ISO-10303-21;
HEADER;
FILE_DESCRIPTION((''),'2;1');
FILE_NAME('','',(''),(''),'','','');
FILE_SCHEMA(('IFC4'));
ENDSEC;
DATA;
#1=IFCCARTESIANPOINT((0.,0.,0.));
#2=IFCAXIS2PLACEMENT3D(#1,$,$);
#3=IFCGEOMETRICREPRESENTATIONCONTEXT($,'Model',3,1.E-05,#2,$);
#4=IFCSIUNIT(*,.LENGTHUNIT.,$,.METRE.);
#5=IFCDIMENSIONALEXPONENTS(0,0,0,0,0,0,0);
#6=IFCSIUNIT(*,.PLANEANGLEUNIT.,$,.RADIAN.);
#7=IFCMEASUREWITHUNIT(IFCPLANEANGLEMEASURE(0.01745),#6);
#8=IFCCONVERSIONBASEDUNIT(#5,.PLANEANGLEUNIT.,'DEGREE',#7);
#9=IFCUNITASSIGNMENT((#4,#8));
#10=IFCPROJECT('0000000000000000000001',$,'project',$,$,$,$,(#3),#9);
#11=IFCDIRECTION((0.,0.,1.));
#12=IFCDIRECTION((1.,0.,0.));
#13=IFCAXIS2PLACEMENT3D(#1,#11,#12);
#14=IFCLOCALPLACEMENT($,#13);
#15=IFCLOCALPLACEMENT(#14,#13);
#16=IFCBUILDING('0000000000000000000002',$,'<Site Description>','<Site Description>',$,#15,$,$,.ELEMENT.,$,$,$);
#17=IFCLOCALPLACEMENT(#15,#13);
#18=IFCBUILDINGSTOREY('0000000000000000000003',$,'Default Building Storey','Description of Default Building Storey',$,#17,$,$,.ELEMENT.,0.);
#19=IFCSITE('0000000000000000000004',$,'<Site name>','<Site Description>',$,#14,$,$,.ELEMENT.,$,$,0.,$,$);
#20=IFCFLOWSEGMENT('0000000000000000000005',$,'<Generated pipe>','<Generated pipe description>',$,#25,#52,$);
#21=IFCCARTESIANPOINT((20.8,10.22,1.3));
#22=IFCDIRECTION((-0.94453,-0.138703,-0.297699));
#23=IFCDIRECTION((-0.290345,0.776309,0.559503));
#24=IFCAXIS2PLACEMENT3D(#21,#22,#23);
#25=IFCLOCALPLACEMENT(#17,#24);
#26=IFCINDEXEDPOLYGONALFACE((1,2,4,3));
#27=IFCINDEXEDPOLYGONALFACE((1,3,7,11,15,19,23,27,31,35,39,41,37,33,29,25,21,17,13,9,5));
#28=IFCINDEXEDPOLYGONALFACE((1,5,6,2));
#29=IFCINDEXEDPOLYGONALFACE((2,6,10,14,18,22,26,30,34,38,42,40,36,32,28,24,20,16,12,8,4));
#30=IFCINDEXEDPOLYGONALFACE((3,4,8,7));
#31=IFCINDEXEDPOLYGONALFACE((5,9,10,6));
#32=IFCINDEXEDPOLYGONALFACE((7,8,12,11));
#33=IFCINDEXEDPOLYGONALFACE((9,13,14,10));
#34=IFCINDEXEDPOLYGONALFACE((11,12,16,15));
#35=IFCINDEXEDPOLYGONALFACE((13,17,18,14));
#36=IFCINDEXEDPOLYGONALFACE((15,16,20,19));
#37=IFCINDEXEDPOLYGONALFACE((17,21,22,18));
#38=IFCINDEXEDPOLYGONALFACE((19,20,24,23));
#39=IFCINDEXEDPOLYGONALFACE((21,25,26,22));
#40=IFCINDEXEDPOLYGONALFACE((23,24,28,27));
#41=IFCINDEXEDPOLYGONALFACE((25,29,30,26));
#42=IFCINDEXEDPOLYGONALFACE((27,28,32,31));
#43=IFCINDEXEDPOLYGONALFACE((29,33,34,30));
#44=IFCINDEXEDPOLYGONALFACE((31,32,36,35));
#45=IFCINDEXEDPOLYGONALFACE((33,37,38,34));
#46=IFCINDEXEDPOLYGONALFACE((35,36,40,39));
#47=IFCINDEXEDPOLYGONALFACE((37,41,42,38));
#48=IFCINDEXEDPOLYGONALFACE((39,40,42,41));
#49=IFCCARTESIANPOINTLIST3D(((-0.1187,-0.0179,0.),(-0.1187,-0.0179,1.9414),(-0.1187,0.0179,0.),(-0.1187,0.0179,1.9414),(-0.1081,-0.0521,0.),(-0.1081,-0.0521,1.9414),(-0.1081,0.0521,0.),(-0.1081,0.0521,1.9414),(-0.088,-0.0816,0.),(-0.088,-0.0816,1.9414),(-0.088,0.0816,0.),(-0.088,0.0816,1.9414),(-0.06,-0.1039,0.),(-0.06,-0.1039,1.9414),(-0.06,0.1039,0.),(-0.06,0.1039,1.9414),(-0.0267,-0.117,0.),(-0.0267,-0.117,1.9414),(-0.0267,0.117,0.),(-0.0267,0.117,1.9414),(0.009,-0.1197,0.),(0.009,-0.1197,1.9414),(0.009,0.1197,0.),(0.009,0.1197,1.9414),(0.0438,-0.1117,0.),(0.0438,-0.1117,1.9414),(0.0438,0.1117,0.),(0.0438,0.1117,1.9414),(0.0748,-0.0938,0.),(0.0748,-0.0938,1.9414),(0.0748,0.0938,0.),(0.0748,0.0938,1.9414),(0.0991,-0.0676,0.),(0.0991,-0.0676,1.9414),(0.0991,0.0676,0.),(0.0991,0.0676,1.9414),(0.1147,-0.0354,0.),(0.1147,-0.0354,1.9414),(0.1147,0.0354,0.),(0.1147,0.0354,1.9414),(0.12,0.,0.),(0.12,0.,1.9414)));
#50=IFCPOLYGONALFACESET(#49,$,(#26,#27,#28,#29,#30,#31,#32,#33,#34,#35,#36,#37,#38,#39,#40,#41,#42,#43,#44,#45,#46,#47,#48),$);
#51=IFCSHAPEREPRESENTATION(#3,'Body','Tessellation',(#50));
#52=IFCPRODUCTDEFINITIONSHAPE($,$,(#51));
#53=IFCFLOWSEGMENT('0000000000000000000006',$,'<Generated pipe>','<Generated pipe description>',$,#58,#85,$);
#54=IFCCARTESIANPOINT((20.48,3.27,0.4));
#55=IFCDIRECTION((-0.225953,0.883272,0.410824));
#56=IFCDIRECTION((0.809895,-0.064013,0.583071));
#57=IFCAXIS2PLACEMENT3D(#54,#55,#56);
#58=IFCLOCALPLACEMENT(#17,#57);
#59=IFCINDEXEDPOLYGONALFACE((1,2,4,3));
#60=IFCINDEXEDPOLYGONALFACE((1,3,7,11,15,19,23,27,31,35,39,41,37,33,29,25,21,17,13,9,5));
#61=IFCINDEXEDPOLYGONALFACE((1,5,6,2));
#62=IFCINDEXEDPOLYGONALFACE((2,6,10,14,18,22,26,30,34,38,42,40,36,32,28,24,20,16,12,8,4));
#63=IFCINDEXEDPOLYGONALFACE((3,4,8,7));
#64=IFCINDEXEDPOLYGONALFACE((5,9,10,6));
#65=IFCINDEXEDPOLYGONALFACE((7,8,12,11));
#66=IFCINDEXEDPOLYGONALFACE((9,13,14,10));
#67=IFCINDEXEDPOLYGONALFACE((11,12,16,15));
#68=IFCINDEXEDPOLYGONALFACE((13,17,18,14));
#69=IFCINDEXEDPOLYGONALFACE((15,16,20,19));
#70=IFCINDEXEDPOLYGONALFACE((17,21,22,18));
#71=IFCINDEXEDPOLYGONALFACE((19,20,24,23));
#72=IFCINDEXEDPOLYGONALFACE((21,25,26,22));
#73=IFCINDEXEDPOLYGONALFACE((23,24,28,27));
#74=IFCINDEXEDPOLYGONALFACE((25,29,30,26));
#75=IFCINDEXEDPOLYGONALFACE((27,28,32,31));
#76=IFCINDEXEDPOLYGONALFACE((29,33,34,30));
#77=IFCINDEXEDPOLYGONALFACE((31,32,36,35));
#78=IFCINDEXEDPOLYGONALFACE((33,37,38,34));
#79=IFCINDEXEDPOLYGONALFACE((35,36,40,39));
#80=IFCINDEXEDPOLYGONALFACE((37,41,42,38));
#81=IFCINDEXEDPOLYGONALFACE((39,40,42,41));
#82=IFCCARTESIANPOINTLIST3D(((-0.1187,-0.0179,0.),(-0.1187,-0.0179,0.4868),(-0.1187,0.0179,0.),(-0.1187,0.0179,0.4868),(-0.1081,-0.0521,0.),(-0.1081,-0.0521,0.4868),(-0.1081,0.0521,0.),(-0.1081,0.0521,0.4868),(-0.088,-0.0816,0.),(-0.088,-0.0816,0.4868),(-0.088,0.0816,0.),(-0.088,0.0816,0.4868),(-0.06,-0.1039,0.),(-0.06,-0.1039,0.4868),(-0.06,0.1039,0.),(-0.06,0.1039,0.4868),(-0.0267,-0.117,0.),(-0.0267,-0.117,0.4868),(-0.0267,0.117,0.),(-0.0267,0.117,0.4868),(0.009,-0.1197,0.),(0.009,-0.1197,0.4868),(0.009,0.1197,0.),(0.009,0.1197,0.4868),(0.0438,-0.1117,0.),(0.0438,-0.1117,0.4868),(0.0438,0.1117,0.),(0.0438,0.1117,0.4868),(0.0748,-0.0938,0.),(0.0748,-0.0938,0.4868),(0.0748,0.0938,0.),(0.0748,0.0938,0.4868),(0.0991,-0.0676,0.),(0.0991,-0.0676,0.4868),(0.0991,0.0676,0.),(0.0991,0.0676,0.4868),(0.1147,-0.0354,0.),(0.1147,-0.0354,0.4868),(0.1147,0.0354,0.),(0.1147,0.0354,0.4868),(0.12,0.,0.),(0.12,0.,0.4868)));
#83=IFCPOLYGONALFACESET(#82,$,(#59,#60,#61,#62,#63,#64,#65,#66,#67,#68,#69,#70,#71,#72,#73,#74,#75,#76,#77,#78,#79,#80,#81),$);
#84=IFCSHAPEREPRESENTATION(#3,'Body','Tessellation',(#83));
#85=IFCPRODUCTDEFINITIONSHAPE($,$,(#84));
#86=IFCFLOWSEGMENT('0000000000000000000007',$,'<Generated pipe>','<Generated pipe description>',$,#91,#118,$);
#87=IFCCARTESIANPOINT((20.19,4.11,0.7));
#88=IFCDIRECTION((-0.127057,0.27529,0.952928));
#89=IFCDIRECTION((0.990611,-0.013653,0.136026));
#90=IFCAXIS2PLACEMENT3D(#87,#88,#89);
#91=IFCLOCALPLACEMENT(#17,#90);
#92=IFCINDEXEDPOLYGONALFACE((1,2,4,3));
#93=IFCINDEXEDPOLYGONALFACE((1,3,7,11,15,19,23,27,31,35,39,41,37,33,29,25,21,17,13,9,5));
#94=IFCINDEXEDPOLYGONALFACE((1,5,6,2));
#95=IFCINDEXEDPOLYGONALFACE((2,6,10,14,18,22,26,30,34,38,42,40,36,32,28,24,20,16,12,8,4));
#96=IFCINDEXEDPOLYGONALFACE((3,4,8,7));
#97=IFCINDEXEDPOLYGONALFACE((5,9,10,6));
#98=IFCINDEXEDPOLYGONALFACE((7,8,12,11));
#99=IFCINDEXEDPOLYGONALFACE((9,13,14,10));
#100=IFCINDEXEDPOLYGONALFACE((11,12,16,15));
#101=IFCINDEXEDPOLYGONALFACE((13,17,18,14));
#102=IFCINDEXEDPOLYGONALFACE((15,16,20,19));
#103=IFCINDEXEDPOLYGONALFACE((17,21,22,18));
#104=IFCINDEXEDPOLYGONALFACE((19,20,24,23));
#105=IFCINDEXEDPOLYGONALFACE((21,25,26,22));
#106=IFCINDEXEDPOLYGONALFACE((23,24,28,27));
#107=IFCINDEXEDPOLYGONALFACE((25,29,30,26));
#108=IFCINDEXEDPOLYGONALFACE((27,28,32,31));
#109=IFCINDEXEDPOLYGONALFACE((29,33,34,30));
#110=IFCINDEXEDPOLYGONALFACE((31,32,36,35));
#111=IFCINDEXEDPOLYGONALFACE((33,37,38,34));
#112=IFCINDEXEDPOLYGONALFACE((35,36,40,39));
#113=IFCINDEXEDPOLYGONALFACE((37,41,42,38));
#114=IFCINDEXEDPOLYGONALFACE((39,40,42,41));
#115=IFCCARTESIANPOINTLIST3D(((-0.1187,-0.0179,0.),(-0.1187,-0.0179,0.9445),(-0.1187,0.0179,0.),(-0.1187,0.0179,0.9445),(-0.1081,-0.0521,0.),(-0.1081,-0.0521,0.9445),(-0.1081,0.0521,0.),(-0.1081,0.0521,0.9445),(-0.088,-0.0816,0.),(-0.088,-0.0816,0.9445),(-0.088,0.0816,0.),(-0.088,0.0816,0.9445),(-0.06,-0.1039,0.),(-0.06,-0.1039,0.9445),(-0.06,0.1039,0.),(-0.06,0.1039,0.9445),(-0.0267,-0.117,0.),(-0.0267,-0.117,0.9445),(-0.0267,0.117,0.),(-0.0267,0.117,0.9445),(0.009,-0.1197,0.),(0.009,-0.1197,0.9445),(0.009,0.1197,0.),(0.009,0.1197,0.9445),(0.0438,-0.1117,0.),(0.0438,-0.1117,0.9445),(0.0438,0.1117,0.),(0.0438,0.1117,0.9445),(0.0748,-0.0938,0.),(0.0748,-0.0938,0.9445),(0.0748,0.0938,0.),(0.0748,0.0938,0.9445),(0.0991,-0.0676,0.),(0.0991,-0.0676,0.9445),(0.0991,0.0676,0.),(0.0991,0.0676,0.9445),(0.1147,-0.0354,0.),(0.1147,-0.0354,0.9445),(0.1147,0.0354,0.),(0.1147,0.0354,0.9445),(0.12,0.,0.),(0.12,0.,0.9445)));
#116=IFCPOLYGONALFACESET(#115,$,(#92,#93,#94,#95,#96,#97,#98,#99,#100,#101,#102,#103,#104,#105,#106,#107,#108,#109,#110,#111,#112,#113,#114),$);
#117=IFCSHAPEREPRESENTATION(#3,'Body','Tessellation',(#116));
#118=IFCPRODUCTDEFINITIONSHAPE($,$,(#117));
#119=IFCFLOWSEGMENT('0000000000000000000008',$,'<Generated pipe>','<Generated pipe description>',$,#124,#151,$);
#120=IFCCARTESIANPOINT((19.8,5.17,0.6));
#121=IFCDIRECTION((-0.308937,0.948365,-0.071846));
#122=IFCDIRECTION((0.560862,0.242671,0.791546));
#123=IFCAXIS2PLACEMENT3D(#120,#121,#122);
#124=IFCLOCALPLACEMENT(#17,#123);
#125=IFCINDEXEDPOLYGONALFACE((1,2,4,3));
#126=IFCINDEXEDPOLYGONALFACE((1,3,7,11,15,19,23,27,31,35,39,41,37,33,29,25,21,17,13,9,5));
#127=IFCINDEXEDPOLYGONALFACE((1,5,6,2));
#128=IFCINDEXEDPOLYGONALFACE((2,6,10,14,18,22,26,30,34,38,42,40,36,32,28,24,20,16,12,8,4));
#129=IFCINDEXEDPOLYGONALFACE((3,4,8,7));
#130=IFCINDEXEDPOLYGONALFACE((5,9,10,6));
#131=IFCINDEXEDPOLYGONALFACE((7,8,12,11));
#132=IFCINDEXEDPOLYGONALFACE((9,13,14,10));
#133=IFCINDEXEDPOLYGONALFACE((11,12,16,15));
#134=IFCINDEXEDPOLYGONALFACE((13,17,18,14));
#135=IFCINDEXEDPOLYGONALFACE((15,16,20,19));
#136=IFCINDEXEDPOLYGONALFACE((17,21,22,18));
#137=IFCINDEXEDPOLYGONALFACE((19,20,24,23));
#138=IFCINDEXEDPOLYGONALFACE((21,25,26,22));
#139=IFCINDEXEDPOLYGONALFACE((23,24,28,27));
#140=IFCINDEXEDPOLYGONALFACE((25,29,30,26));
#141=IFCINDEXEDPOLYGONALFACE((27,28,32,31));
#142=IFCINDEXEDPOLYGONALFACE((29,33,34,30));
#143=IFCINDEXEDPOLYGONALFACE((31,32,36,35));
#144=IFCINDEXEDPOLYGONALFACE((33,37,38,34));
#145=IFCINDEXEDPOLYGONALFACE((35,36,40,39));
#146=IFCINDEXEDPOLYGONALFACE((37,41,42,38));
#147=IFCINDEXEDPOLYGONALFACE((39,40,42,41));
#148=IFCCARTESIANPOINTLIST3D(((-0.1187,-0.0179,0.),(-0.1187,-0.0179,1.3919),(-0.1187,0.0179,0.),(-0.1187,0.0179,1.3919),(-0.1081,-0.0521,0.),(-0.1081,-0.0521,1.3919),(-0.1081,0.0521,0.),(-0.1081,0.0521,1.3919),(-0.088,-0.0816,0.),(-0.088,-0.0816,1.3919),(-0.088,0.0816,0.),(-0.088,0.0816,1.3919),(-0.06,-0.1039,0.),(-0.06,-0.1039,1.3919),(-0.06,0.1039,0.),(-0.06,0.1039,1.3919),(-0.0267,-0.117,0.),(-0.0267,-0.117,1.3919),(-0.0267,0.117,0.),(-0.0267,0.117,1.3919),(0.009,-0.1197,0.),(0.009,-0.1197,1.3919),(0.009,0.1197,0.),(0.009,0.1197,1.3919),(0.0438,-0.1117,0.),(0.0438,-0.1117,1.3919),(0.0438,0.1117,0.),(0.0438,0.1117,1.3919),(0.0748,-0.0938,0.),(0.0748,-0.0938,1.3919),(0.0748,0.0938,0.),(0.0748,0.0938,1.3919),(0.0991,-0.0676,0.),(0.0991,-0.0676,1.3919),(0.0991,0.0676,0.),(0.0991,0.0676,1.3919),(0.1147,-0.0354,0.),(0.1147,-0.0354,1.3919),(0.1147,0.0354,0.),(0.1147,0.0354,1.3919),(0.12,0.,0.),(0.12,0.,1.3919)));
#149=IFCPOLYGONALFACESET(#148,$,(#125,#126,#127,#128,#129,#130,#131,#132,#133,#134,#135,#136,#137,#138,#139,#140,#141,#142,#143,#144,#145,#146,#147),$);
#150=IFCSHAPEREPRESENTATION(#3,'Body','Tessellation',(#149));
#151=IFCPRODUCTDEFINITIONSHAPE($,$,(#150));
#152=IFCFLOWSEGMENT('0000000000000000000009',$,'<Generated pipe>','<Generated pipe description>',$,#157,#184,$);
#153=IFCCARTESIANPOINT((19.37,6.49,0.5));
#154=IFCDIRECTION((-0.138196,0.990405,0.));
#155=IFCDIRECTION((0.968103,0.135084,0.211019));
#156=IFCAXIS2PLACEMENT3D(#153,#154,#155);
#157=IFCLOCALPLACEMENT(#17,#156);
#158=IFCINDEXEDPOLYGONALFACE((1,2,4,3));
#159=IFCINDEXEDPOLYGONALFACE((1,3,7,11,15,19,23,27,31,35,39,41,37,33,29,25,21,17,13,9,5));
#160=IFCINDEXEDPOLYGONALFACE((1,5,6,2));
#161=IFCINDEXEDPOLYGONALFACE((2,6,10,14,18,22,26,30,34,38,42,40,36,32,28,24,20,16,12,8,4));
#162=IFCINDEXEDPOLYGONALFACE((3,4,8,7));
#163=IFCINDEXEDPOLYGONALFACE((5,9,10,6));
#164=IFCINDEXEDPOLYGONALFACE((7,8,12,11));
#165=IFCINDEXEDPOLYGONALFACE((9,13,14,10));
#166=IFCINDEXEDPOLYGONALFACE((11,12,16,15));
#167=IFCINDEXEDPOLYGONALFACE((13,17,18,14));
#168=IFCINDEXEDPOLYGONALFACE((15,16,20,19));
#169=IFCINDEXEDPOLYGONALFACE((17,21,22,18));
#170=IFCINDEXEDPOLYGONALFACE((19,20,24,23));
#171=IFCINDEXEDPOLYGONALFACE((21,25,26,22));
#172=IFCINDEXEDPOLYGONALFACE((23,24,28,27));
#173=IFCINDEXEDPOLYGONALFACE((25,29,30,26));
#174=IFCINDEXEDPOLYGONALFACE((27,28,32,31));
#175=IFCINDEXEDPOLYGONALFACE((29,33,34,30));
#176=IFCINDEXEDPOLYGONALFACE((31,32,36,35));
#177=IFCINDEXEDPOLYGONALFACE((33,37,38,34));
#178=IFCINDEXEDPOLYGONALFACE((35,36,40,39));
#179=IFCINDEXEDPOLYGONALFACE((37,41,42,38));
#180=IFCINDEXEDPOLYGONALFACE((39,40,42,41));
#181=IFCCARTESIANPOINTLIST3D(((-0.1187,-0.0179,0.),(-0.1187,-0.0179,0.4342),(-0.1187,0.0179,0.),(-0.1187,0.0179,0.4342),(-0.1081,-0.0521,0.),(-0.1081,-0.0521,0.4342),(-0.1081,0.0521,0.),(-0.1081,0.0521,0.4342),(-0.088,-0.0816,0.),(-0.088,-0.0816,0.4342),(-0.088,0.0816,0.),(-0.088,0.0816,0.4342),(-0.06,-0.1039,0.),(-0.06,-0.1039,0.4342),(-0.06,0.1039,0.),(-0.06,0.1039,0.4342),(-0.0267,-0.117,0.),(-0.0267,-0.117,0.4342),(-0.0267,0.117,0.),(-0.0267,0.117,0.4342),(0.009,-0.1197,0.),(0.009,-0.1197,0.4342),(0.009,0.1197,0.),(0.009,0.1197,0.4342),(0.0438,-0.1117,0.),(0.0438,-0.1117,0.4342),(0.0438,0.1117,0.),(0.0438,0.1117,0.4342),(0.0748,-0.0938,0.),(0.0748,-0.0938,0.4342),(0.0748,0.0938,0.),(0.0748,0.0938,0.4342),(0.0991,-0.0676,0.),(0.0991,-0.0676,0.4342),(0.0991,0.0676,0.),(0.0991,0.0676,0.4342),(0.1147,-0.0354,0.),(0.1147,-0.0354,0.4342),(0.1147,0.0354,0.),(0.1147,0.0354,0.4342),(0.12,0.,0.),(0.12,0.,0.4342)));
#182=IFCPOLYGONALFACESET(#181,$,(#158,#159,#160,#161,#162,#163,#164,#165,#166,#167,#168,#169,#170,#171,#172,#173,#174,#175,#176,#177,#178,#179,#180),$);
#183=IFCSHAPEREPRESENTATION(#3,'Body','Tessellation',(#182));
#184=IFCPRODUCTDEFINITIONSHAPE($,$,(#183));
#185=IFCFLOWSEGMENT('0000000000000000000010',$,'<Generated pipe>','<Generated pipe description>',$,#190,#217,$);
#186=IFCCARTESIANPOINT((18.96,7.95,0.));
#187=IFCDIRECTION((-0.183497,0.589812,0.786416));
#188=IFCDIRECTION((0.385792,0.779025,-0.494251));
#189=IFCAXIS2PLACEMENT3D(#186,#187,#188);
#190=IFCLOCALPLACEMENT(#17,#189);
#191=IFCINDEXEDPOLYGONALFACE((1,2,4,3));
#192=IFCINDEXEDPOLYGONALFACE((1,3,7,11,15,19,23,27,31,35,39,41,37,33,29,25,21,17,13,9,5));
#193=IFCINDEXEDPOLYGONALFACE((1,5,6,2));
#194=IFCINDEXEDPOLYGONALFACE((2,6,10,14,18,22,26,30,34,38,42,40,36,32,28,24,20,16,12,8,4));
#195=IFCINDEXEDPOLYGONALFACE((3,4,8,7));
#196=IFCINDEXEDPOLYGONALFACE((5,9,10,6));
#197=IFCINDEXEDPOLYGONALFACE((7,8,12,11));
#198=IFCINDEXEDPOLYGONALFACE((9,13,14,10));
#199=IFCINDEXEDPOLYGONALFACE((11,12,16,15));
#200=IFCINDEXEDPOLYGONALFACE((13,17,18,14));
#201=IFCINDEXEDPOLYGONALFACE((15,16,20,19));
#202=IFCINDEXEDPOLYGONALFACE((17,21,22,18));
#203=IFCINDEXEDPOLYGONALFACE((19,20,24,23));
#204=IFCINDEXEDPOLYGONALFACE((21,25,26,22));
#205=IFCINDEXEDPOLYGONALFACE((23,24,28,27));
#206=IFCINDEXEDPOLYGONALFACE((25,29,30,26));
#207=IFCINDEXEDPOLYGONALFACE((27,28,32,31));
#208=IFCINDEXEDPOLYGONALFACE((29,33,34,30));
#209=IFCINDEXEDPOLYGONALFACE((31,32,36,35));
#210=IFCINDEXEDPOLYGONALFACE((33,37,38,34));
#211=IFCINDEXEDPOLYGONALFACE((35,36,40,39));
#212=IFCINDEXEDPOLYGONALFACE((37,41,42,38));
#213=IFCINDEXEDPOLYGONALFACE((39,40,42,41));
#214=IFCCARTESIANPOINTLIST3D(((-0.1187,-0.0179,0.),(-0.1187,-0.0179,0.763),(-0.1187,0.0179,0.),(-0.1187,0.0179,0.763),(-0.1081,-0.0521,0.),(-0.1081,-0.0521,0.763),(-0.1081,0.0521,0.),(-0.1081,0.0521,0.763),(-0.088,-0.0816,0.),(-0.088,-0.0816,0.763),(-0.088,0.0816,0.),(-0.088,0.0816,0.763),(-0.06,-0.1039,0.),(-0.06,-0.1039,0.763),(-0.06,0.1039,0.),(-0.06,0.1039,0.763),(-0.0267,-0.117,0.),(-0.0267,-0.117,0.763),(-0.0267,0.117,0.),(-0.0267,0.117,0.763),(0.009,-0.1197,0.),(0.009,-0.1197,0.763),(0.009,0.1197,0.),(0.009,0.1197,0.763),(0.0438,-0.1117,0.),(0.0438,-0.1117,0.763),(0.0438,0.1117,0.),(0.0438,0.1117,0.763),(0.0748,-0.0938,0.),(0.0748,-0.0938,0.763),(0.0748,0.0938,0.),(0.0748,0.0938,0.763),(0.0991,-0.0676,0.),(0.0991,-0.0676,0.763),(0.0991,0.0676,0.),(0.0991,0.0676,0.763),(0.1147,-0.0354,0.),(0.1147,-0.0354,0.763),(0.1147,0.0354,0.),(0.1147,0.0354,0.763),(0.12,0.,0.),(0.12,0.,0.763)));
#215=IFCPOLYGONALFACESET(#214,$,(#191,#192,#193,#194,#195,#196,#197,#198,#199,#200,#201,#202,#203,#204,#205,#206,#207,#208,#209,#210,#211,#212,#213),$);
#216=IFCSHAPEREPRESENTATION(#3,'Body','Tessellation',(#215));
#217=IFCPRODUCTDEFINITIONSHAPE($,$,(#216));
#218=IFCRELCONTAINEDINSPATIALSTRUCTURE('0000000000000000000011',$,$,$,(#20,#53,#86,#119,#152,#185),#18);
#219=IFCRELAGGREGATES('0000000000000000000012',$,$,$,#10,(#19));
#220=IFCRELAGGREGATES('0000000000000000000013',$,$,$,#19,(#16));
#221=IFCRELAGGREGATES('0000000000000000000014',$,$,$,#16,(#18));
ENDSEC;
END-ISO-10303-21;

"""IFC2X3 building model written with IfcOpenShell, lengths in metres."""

from ifc_helpers import new_model, entity, si_unit, converted_unit, frame, origin, origin_with_axes, origin_2d_with_axis, place, context, project, spatial, circle, extrude, element, save


model = new_model("IFC2X3")

# Units and contexts
model_context = context("Model", 3, precision=1e-05, world=origin())
ifc_project = project(units=[si_unit("LENGTHUNIT", "METRE"), converted_unit("PLANEANGLEUNIT", "DEGREE", entity("IfcPlaneAngleMeasure", 0.01745), si_unit("PLANEANGLEUNIT", "RADIAN"), dimensions=[0, 0, 0, 0, 0, 0, 0])], contexts=[model_context])

# Site, building, storey
site_placement = place(None, origin_with_axes())
site = spatial("IfcSite", under=ifc_project, at=site_placement, Name="<Site name>", Description="<Site Description>", CompositionType="ELEMENT", RefElevation=0.0)
building_placement = place(site_placement, origin_with_axes())
building = spatial("IfcBuilding", under=site, at=building_placement, Name="<Site Description>", Description="<Site Description>", CompositionType="ELEMENT")
storey_placement = place(building_placement, origin_with_axes())
storey = spatial("IfcBuildingStorey", under=building, at=storey_placement, Name="Default Building Storey", Description="Description of Default Building Storey", CompositionType="ELEMENT", Elevation=0.0)

# Flow segments
flow_segment_1_placement = place(storey_placement, frame((20.8, 10.22, 1.3), z_axis=(-0.94453, -0.138703, -0.297699), x_axis=(-0.290345, 0.776309, 0.559503)))
element("IfcFlowSegment", 1, at=flow_segment_1_placement, inside=storey, Name="<Generated pipe>", Description="<Generated pipe description>", context=model_context, shape_type="SweptSolid", body=[
    extrude(circle(Radius=0.12, at=origin_2d_with_axis()), origin_with_axes(), (0.0, 0.0, 1.0), 1.9414),
])
flow_segment_2_placement = place(storey_placement, frame((20.48, 3.27, 0.4), z_axis=(-0.225953, 0.883272, 0.410824), x_axis=(0.809895, -0.064013, 0.583071)))
element("IfcFlowSegment", 2, at=flow_segment_2_placement, inside=storey, Name="<Generated pipe>", Description="<Generated pipe description>", context=model_context, shape_type="SweptSolid", body=[
    extrude(circle(Radius=0.12, at=origin_2d_with_axis()), origin_with_axes(), (0.0, 0.0, 1.0), 0.4868),
])
flow_segment_3_placement = place(storey_placement, frame((20.19, 4.11, 0.7), z_axis=(-0.127057, 0.27529, 0.952928), x_axis=(0.990611, -0.013653, 0.136026)))
element("IfcFlowSegment", 3, at=flow_segment_3_placement, inside=storey, Name="<Generated pipe>", Description="<Generated pipe description>", context=model_context, shape_type="SweptSolid", body=[
    extrude(circle(Radius=0.12, at=origin_2d_with_axis()), origin_with_axes(), (0.0, 0.0, 1.0), 0.9445),
])
flow_segment_4_placement = place(storey_placement, frame((19.8, 5.17, 0.6), z_axis=(-0.308937, 0.948365, -0.071846), x_axis=(0.560862, 0.242671, 0.791546)))
element("IfcFlowSegment", 4, at=flow_segment_4_placement, inside=storey, Name="<Generated pipe>", Description="<Generated pipe description>", context=model_context, shape_type="SweptSolid", body=[
    extrude(circle(Radius=0.12, at=origin_2d_with_axis()), origin_with_axes(), (0.0, 0.0, 1.0), 1.3919),
])
flow_segment_5_placement = place(storey_placement, frame((19.37, 6.49, 0.5), z_axis=(-0.138196, 0.990405, 0.0), x_axis=(0.968103, 0.135084, 0.211019)))
element("IfcFlowSegment", 5, at=flow_segment_5_placement, inside=storey, Name="<Generated pipe>", Description="<Generated pipe description>", context=model_context, shape_type="SweptSolid", body=[
    extrude(circle(Radius=0.12, at=origin_2d_with_axis()), origin_with_axes(), (0.0, 0.0, 1.0), 0.4342),
])
flow_segment_6_placement = place(storey_placement, frame((18.96, 7.95, 0.0), z_axis=(-0.183497, 0.589812, 0.786416), x_axis=(0.385792, 0.779025, -0.494251)))
element("IfcFlowSegment", 6, at=flow_segment_6_placement, inside=storey, Name="<Generated pipe>", Description="<Generated pipe description>", context=model_context, shape_type="SweptSolid", body=[
    extrude(circle(Radius=0.12, at=origin_2d_with_axis()), origin_with_axes(), (0.0, 0.0, 1.0), 0.763),
])

save(model, "model.ifc")
